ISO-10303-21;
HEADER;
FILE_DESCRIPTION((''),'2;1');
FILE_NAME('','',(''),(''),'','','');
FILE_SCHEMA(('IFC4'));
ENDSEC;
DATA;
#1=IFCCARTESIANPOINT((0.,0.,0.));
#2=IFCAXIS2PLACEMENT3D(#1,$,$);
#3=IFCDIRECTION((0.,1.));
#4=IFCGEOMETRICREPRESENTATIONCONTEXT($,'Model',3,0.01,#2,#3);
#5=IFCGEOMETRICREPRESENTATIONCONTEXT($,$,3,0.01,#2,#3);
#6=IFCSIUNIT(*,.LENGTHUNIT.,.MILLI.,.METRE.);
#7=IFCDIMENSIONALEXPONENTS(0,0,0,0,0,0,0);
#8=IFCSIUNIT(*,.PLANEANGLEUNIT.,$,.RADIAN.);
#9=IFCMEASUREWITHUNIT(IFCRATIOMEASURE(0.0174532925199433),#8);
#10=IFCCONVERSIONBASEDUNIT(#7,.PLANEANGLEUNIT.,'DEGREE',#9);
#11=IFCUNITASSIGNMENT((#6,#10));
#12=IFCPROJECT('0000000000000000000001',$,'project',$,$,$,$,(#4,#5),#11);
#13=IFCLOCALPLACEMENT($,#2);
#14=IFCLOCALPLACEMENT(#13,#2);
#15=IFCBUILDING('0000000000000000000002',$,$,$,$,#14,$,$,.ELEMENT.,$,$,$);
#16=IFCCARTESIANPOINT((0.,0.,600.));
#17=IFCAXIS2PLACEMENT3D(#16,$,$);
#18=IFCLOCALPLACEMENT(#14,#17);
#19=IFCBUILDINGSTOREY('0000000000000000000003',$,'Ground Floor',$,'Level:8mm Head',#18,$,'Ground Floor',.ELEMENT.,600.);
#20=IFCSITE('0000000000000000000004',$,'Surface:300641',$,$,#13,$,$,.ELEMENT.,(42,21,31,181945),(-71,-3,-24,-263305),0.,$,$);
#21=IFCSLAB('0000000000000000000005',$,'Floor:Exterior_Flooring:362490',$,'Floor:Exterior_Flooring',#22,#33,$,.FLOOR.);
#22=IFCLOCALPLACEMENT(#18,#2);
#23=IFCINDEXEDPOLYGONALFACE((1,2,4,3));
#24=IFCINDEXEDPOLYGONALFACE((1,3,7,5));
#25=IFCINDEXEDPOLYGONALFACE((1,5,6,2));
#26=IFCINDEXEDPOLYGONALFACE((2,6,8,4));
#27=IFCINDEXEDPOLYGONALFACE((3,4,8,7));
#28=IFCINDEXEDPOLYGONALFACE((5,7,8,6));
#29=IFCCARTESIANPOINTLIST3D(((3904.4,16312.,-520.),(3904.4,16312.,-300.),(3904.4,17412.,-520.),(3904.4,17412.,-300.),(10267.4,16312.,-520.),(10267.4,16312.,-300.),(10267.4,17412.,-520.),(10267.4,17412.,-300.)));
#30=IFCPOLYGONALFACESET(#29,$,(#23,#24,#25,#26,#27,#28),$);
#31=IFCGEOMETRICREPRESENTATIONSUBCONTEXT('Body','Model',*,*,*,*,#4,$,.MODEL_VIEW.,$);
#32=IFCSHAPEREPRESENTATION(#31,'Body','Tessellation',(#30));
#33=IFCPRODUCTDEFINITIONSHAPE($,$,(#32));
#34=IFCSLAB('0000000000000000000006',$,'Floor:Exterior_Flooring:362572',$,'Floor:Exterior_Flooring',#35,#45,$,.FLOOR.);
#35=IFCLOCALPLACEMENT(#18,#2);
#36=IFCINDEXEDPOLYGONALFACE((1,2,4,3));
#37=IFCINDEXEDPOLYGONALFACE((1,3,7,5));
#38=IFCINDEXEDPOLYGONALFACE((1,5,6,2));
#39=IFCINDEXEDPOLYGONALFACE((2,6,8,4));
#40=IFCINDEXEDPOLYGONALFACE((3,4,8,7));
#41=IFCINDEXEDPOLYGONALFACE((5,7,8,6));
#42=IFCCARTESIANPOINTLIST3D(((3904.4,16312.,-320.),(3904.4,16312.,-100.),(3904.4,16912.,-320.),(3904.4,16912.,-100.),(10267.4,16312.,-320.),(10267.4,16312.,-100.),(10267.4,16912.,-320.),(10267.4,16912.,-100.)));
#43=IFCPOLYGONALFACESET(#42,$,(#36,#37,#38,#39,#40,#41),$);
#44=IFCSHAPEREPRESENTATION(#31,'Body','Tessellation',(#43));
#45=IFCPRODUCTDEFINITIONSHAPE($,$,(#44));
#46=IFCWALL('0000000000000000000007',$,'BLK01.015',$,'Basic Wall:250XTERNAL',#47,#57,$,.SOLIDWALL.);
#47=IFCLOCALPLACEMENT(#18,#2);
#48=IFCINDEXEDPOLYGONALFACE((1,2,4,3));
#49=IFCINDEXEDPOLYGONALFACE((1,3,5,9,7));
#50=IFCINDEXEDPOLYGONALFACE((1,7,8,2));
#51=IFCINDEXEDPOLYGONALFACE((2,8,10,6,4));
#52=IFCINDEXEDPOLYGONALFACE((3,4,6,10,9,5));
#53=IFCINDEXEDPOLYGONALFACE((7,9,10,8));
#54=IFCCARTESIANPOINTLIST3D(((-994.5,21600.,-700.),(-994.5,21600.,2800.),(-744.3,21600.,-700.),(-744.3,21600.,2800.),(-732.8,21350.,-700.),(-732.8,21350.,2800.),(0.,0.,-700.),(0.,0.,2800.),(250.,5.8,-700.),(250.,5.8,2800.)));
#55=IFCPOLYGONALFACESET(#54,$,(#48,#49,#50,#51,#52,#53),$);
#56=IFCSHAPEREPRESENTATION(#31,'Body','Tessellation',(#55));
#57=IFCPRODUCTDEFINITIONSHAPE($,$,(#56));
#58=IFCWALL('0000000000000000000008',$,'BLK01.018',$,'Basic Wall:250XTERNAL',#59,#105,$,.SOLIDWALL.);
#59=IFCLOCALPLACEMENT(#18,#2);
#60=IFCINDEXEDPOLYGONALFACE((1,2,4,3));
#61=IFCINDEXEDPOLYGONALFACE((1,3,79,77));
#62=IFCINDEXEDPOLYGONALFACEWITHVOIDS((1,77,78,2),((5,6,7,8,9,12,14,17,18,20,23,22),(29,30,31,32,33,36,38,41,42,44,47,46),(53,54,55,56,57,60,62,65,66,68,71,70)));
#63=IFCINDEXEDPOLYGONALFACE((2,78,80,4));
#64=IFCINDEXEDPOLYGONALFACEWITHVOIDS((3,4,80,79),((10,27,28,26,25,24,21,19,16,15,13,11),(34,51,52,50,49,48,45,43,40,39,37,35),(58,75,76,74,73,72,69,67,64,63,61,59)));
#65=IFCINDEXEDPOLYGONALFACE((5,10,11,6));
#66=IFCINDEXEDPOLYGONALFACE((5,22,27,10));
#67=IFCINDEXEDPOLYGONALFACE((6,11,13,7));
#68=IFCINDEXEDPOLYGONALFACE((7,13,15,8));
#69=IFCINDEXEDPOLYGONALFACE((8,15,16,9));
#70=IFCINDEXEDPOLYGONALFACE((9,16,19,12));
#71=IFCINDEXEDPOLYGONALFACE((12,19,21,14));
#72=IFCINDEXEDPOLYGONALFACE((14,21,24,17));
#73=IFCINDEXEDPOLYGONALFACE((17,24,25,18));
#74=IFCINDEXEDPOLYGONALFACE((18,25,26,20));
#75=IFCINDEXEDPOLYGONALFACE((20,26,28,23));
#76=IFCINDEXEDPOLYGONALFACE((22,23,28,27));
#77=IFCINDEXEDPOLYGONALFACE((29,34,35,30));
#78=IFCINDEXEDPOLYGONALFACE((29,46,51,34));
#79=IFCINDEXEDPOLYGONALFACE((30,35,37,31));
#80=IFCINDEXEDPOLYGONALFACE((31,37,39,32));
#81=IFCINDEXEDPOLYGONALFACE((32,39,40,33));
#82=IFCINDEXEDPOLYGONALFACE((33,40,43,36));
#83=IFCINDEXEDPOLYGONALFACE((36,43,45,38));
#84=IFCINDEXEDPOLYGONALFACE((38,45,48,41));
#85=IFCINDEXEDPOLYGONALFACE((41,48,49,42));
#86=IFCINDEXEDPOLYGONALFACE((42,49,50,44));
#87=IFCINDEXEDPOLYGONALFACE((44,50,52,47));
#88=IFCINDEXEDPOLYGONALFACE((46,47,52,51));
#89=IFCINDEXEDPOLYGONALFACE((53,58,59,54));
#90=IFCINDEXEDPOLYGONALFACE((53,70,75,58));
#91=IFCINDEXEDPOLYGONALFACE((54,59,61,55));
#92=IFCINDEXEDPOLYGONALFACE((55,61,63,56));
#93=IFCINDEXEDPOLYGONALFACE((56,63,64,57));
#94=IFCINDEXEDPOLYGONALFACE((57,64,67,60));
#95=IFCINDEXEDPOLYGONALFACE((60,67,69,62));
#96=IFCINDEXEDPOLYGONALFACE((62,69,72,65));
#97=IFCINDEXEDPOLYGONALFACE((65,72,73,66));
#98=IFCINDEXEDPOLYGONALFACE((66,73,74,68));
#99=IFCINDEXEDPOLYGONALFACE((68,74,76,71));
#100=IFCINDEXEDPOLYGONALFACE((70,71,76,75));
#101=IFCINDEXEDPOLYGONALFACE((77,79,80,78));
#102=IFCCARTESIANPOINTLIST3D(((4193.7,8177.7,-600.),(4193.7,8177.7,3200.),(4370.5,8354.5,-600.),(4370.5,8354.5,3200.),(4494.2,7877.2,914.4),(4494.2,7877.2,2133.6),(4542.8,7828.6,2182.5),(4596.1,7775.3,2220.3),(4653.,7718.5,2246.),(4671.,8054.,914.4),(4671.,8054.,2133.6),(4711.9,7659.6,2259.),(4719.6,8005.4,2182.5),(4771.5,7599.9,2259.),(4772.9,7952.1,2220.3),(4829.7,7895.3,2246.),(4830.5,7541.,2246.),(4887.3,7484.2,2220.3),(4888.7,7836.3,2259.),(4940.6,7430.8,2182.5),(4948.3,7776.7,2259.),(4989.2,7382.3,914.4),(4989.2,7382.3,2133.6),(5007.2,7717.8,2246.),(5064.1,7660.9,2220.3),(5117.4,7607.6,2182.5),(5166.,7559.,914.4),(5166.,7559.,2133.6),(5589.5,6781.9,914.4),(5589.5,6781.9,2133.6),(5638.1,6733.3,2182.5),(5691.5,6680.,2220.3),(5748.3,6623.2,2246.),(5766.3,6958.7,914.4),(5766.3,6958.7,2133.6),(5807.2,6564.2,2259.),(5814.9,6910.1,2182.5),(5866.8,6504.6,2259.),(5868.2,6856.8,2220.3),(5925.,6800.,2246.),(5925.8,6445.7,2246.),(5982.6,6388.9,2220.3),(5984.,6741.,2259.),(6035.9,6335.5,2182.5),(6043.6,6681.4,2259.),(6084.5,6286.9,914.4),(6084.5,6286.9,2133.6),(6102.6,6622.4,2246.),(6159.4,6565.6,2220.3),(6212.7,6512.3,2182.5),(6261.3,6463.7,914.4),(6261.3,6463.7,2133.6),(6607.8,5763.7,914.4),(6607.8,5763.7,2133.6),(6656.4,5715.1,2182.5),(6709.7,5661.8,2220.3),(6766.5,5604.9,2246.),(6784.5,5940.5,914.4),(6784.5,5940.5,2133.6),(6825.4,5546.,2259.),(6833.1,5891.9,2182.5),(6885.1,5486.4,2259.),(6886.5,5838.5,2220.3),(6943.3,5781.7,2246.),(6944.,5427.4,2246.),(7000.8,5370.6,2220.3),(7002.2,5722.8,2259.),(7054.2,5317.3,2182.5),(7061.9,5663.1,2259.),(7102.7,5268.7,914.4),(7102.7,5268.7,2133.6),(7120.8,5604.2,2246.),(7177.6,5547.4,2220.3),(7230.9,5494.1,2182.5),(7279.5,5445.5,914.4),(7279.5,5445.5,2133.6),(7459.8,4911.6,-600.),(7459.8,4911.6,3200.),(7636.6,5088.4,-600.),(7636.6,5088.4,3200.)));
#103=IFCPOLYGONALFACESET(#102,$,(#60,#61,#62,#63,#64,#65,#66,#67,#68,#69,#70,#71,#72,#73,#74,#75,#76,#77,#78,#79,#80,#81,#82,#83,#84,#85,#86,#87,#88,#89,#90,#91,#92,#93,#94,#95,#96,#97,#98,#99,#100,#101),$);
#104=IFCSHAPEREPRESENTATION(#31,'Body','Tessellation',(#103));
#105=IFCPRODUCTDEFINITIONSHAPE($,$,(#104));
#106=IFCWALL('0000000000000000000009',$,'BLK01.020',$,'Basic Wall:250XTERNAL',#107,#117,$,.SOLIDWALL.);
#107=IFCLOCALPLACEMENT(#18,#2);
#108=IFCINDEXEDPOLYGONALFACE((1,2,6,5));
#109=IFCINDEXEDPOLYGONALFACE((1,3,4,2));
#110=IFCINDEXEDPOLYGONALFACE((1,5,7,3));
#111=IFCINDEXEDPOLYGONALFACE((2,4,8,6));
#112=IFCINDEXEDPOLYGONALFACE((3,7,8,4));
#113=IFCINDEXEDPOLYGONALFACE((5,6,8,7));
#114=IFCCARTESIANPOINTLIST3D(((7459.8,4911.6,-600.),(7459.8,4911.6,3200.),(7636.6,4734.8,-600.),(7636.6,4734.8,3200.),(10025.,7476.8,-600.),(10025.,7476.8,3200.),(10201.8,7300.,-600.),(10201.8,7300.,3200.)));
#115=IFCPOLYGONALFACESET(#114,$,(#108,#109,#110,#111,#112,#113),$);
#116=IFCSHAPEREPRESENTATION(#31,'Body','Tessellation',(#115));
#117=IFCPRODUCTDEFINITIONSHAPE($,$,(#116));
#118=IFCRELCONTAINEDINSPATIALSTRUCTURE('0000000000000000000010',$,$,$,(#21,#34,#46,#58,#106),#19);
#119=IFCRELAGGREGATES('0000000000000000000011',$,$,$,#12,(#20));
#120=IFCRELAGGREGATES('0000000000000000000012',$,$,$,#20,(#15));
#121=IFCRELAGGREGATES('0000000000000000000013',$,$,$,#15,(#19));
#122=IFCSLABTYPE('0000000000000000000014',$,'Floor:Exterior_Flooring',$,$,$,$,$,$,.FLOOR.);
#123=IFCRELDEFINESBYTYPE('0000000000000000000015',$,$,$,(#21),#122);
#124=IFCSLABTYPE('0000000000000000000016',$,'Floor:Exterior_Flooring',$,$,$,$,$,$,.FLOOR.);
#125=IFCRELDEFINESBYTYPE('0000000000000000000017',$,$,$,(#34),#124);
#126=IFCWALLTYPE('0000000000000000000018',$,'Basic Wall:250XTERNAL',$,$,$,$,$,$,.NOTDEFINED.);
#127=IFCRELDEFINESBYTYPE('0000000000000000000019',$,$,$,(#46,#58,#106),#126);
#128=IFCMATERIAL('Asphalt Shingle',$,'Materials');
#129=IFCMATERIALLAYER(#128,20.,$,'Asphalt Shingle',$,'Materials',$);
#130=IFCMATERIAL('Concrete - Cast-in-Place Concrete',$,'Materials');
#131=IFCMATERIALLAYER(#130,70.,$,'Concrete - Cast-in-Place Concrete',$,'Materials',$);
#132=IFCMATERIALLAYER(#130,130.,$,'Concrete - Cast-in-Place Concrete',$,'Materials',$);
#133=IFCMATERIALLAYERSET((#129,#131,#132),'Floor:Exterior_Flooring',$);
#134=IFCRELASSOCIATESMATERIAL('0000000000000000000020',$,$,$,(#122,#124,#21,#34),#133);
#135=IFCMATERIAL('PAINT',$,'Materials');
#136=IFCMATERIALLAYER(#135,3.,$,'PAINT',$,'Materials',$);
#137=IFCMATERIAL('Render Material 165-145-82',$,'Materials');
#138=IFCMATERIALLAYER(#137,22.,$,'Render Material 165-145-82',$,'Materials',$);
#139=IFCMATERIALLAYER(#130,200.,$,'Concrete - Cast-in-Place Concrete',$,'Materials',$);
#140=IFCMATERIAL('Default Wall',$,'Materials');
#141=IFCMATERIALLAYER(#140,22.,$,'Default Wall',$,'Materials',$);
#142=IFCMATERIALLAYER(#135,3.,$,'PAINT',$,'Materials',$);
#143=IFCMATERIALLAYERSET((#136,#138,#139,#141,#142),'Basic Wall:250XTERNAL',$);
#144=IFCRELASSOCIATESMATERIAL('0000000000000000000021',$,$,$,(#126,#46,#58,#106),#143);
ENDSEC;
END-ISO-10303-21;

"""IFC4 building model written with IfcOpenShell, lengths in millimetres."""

from ifc_helpers import new_model, entity, si_unit, converted_unit, direction, frame, frame_2d, origin, origin_2d_with_axis, place, context, subcontext, project, spatial, polyline, circle_curve, parameter, trimmed, segment, composite_curve, rectangle, outline, extrude, clip, halfspace, material, layer, layer_set, layer_usage, type_object, element, save


model = new_model("IFC4")

# Units and contexts
model_context = context("Model", 3, precision=0.01, world=origin(), true_north=direction((0.0, 1.0)))
context_of_model = context(None, 3, precision=0.01, world=origin(), true_north=direction((0.0, 1.0)))
body_context = subcontext(model_context, "Body", "Model", "MODEL_VIEW")
ifc_project = project(units=[si_unit("LENGTHUNIT", "METRE", prefix="MILLI"), converted_unit("PLANEANGLEUNIT", "DEGREE", entity("IfcRatioMeasure", 0.0174532925199433), si_unit("PLANEANGLEUNIT", "RADIAN"), dimensions=[0, 0, 0, 0, 0, 0, 0])], contexts=[model_context, context_of_model])

# Site, building, storey
site_placement = place(None, origin())
site = spatial("IfcSite", under=ifc_project, at=site_placement, Name="Surface:300641", CompositionType="ELEMENT", RefLatitude=(42, 21, 31, 181945), RefLongitude=(-71, -3, -24, -263305), RefElevation=0.0)
building_placement = place(site_placement, origin())
building = spatial("IfcBuilding", under=site, at=building_placement, CompositionType="ELEMENT")
storey_placement = place(building_placement, frame((0.0, 0.0, 600.0)))
storey = spatial("IfcBuildingStorey", under=building, at=storey_placement, Name="Ground Floor", ObjectType="Level:8mm Head", LongName="Ground Floor", CompositionType="ELEMENT", Elevation=600.0)

# Shared definitions
ifc_material_1 = material(Name="Concrete - Cast-in-Place Concrete", Category="Materials")

# Slabs
ifc_material_2 = material(Name="Asphalt Shingle", Category="Materials")
ifc_layer_1 = layer(ifc_material_2, 20.0, Name="Asphalt Shingle", Category="Materials")
ifc_layer_2 = layer(ifc_material_1, 70.0, Name="Concrete - Cast-in-Place Concrete", Category="Materials")
ifc_layer_3 = layer(ifc_material_1, 130.0, Name="Concrete - Cast-in-Place Concrete", Category="Materials")
ifc_layer_set_1 = layer_set([ifc_layer_1, ifc_layer_2, ifc_layer_3], Name="Floor:Exterior_Flooring")
ifc_layer_usage_1 = layer_usage(ifc_layer_set_1, "AXIS3", "POSITIVE", 0.0)
slab_type_1 = type_object("IfcSlabType", Name="Floor:Exterior_Flooring", PredefinedType="FLOOR", material=ifc_layer_set_1)
slab_1_placement = place(storey_placement, origin())
element("IfcSlab", 1, at=slab_1_placement, inside=storey, type_object=slab_type_1, material=ifc_layer_usage_1, Name="Floor:Exterior_Flooring:362490", ObjectType="Floor:Exterior_Flooring", PredefinedType="FLOOR", context=body_context, shape_type="SweptSolid", body=[
    extrude(rectangle(XDim=1100.0, YDim=6362.9, at=origin_2d_with_axis()), frame((7085.9, 16862.0, -300.0), z_axis=(0.0, 0.0, -1.0), x_axis=(0.0, 1.0, 0.0)), (0.0, 0.0, 1.0), 220.0),
])
ifc_layer_usage_2 = layer_usage(ifc_layer_set_1, "AXIS3", "POSITIVE", 0.0)
slab_type_2 = type_object("IfcSlabType", Name="Floor:Exterior_Flooring", PredefinedType="FLOOR", material=ifc_layer_set_1)
slab_2_placement = place(storey_placement, origin())
element("IfcSlab", 2, at=slab_2_placement, inside=storey, type_object=slab_type_2, material=ifc_layer_usage_2, Name="Floor:Exterior_Flooring:362572", ObjectType="Floor:Exterior_Flooring", PredefinedType="FLOOR", context=body_context, shape_type="SweptSolid", body=[
    extrude(rectangle(XDim=600.0, YDim=6362.9, at=frame_2d((0.0, 0.0), x_axis=(1.0, 0.0))), frame((7085.9, 16612.0, -100.0), z_axis=(0.0, 0.0, -1.0), x_axis=(0.0, 1.0, 0.0)), (0.0, 0.0, 1.0), 220.0),
])

# Wall
ifc_material_3 = material(Name="PAINT", Category="Materials")
ifc_layer_4 = layer(ifc_material_3, 3.0, Name="PAINT", Category="Materials")
ifc_material_4 = material(Name="Render Material 165-145-82", Category="Materials")
ifc_layer_5 = layer(ifc_material_4, 22.0, Name="Render Material 165-145-82", Category="Materials")
ifc_layer_6 = layer(ifc_material_1, 200.0, Name="Concrete - Cast-in-Place Concrete", Category="Materials")
ifc_material_5 = material(Name="Default Wall", Category="Materials")
ifc_layer_7 = layer(ifc_material_5, 22.0, Name="Default Wall", Category="Materials")
ifc_layer_8 = layer(ifc_material_3, 3.0, Name="PAINT", Category="Materials")
ifc_layer_set_2 = layer_set([ifc_layer_4, ifc_layer_5, ifc_layer_6, ifc_layer_7, ifc_layer_8], Name="Basic Wall:250XTERNAL")
ifc_layer_usage_3 = layer_usage(ifc_layer_set_2, "AXIS2", "NEGATIVE", 125.0)
wall_type_1 = type_object("IfcWallType", Name="Basic Wall:250XTERNAL", PredefinedType="NOTDEFINED", material=ifc_layer_set_2)
wall_1_placement = place(storey_placement, frame((125.1, 0.0, -700.0), z_axis=(0.0, 0.0, 1.0), x_axis=(-0.045995, 0.998942, 0.0)))
element("IfcWall", 3, at=wall_1_placement, inside=storey, type_object=wall_type_1, material=ifc_layer_usage_3, Name="BLK01.015", ObjectType="Basic Wall:250XTERNAL", PredefinedType="SOLIDWALL", context=body_context, shape_type="SweptSolid", body=[
    extrude(outline(polyline([(21617.1, -125.0), (21628.6, 125.0), (5.8, 125.0), (0.0, -125.0), (21366.9, -125.0), (21617.1, -125.0)])), origin(), (0.0, 0.0, 1.0), 3500.0),
])

# Wall, openings
ifc_layer_usage_4 = layer_usage(ifc_layer_set_2, "AXIS2", "NEGATIVE", 125.0)
wall_2_placement = place(storey_placement, frame((7548.2, 5000.0, -600.0), z_axis=(0.0, 0.0, 1.0), x_axis=(-0.707107, 0.707107, 0.0)))
wall_2 = element("IfcWall", 4, at=wall_2_placement, inside=storey, type_object=wall_type_1, material=ifc_layer_usage_4, Name="BLK01.018", ObjectType="Basic Wall:250XTERNAL", PredefinedType="SOLIDWALL", context=body_context, shape_type="Clipping", body=[
    clip(extrude(rectangle(XDim=4619.0, YDim=250.0, at=frame_2d((2309.5, 0.0), x_axis=(-1.0, 0.0))), origin(), (0.0, 0.0, 1.0), 3800.0), halfspace(frame((0.0, 0.0, -600.0)), True)),
])
opening_1_placement = place(wall_2_placement, frame((1205.0, 125.0, 1514.4)))
element("IfcOpeningElement", 5, at=opening_1_placement, cuts=wall_2, ObjectType="Opening", PredefinedType="OPENING", context=body_context, shape_type="SweptSolid", body=[
    extrude(outline(composite_curve([segment(polyline([(0.0, 0.0), (1219.2, 0.0)]), True, "CONTINUOUS"), segment(trimmed(circle_curve(frame_2d((800.4, 350.0), x_axis=(0.0, 1.0)), 545.8), [parameter(230.112671)], [parameter(309.887329)], True, "PARAMETER"), True, "CONTINUOUS"), segment(polyline([(1219.2, 700.0), (0.0, 700.0)]), True, "CONTINUOUS"), segment(polyline([(0.0, 700.0), (0.0, 0.0)]), True, "CONTINUOUS")], self_intersect=False)), frame((0.0, 0.0, 0.0), z_axis=(0.0, -1.0, 0.0), x_axis=(0.0, 0.0, 1.0)), (0.0, 0.0, 1.0), 250.0),
])
opening_2_placement = place(wall_2_placement, frame((2645.0, 125.0, 1514.4)))
element("IfcOpeningElement", 6, at=opening_2_placement, cuts=wall_2, ObjectType="Opening", PredefinedType="OPENING", context=body_context, shape_type="SweptSolid", body=[
    extrude(outline(composite_curve([segment(polyline([(0.0, 0.0), (1219.2, 0.0)]), True, "CONTINUOUS"), segment(trimmed(circle_curve(frame_2d((800.4, 350.0), x_axis=(0.0, 1.0)), 545.8), [parameter(230.112671)], [parameter(309.887329)], True, "PARAMETER"), True, "CONTINUOUS"), segment(polyline([(1219.2, 700.0), (0.0, 700.0)]), True, "CONTINUOUS"), segment(polyline([(0.0, 700.0), (0.0, 0.0)]), True, "CONTINUOUS")], self_intersect=False)), frame((0.0, 0.0, 0.0), z_axis=(0.0, -1.0, 0.0), x_axis=(0.0, 0.0, 1.0)), (0.0, 0.0, 1.0), 250.0),
])
opening_3_placement = place(wall_2_placement, frame((4194.0, 125.0, 1514.4)))
element("IfcOpeningElement", 7, at=opening_3_placement, cuts=wall_2, ObjectType="Opening", PredefinedType="OPENING", context=body_context, shape_type="SweptSolid", body=[
    extrude(outline(composite_curve([segment(polyline([(0.0, 0.0), (1219.2, 0.0)]), True, "CONTINUOUS"), segment(trimmed(circle_curve(frame_2d((800.4, 350.0), x_axis=(0.0, 1.0)), 545.8), [parameter(230.112671)], [parameter(309.887329)], True, "PARAMETER"), True, "CONTINUOUS"), segment(polyline([(1219.2, 700.0), (0.0, 700.0)]), True, "CONTINUOUS"), segment(polyline([(0.0, 700.0), (0.0, 0.0)]), True, "CONTINUOUS")], self_intersect=False)), frame((0.0, 0.0, 0.0), z_axis=(0.0, -1.0, 0.0), x_axis=(0.0, 0.0, 1.0)), (0.0, 0.0, 1.0), 250.0),
])

# Wall
ifc_layer_usage_5 = layer_usage(ifc_layer_set_2, "AXIS2", "NEGATIVE", 125.0)
wall_3_placement = place(storey_placement, frame((7548.2, 4823.2, -600.0), z_axis=(0.0, 0.0, 1.0), x_axis=(0.707107, 0.707107, 0.0)))
element("IfcWall", 8, at=wall_3_placement, inside=storey, type_object=wall_type_1, material=ifc_layer_usage_5, Name="BLK01.020", ObjectType="Basic Wall:250XTERNAL", PredefinedType="SOLIDWALL", context=body_context, shape_type="Clipping", body=[
    clip(extrude(rectangle(XDim=3627.7, YDim=250.0, at=frame_2d((1813.8, 0.0), x_axis=(-1.0, 0.0))), origin(), (0.0, 0.0, 1.0), 3800.0), halfspace(frame((0.0, 0.0, -600.0)), True)),
])

save(model, "model.ifc")
